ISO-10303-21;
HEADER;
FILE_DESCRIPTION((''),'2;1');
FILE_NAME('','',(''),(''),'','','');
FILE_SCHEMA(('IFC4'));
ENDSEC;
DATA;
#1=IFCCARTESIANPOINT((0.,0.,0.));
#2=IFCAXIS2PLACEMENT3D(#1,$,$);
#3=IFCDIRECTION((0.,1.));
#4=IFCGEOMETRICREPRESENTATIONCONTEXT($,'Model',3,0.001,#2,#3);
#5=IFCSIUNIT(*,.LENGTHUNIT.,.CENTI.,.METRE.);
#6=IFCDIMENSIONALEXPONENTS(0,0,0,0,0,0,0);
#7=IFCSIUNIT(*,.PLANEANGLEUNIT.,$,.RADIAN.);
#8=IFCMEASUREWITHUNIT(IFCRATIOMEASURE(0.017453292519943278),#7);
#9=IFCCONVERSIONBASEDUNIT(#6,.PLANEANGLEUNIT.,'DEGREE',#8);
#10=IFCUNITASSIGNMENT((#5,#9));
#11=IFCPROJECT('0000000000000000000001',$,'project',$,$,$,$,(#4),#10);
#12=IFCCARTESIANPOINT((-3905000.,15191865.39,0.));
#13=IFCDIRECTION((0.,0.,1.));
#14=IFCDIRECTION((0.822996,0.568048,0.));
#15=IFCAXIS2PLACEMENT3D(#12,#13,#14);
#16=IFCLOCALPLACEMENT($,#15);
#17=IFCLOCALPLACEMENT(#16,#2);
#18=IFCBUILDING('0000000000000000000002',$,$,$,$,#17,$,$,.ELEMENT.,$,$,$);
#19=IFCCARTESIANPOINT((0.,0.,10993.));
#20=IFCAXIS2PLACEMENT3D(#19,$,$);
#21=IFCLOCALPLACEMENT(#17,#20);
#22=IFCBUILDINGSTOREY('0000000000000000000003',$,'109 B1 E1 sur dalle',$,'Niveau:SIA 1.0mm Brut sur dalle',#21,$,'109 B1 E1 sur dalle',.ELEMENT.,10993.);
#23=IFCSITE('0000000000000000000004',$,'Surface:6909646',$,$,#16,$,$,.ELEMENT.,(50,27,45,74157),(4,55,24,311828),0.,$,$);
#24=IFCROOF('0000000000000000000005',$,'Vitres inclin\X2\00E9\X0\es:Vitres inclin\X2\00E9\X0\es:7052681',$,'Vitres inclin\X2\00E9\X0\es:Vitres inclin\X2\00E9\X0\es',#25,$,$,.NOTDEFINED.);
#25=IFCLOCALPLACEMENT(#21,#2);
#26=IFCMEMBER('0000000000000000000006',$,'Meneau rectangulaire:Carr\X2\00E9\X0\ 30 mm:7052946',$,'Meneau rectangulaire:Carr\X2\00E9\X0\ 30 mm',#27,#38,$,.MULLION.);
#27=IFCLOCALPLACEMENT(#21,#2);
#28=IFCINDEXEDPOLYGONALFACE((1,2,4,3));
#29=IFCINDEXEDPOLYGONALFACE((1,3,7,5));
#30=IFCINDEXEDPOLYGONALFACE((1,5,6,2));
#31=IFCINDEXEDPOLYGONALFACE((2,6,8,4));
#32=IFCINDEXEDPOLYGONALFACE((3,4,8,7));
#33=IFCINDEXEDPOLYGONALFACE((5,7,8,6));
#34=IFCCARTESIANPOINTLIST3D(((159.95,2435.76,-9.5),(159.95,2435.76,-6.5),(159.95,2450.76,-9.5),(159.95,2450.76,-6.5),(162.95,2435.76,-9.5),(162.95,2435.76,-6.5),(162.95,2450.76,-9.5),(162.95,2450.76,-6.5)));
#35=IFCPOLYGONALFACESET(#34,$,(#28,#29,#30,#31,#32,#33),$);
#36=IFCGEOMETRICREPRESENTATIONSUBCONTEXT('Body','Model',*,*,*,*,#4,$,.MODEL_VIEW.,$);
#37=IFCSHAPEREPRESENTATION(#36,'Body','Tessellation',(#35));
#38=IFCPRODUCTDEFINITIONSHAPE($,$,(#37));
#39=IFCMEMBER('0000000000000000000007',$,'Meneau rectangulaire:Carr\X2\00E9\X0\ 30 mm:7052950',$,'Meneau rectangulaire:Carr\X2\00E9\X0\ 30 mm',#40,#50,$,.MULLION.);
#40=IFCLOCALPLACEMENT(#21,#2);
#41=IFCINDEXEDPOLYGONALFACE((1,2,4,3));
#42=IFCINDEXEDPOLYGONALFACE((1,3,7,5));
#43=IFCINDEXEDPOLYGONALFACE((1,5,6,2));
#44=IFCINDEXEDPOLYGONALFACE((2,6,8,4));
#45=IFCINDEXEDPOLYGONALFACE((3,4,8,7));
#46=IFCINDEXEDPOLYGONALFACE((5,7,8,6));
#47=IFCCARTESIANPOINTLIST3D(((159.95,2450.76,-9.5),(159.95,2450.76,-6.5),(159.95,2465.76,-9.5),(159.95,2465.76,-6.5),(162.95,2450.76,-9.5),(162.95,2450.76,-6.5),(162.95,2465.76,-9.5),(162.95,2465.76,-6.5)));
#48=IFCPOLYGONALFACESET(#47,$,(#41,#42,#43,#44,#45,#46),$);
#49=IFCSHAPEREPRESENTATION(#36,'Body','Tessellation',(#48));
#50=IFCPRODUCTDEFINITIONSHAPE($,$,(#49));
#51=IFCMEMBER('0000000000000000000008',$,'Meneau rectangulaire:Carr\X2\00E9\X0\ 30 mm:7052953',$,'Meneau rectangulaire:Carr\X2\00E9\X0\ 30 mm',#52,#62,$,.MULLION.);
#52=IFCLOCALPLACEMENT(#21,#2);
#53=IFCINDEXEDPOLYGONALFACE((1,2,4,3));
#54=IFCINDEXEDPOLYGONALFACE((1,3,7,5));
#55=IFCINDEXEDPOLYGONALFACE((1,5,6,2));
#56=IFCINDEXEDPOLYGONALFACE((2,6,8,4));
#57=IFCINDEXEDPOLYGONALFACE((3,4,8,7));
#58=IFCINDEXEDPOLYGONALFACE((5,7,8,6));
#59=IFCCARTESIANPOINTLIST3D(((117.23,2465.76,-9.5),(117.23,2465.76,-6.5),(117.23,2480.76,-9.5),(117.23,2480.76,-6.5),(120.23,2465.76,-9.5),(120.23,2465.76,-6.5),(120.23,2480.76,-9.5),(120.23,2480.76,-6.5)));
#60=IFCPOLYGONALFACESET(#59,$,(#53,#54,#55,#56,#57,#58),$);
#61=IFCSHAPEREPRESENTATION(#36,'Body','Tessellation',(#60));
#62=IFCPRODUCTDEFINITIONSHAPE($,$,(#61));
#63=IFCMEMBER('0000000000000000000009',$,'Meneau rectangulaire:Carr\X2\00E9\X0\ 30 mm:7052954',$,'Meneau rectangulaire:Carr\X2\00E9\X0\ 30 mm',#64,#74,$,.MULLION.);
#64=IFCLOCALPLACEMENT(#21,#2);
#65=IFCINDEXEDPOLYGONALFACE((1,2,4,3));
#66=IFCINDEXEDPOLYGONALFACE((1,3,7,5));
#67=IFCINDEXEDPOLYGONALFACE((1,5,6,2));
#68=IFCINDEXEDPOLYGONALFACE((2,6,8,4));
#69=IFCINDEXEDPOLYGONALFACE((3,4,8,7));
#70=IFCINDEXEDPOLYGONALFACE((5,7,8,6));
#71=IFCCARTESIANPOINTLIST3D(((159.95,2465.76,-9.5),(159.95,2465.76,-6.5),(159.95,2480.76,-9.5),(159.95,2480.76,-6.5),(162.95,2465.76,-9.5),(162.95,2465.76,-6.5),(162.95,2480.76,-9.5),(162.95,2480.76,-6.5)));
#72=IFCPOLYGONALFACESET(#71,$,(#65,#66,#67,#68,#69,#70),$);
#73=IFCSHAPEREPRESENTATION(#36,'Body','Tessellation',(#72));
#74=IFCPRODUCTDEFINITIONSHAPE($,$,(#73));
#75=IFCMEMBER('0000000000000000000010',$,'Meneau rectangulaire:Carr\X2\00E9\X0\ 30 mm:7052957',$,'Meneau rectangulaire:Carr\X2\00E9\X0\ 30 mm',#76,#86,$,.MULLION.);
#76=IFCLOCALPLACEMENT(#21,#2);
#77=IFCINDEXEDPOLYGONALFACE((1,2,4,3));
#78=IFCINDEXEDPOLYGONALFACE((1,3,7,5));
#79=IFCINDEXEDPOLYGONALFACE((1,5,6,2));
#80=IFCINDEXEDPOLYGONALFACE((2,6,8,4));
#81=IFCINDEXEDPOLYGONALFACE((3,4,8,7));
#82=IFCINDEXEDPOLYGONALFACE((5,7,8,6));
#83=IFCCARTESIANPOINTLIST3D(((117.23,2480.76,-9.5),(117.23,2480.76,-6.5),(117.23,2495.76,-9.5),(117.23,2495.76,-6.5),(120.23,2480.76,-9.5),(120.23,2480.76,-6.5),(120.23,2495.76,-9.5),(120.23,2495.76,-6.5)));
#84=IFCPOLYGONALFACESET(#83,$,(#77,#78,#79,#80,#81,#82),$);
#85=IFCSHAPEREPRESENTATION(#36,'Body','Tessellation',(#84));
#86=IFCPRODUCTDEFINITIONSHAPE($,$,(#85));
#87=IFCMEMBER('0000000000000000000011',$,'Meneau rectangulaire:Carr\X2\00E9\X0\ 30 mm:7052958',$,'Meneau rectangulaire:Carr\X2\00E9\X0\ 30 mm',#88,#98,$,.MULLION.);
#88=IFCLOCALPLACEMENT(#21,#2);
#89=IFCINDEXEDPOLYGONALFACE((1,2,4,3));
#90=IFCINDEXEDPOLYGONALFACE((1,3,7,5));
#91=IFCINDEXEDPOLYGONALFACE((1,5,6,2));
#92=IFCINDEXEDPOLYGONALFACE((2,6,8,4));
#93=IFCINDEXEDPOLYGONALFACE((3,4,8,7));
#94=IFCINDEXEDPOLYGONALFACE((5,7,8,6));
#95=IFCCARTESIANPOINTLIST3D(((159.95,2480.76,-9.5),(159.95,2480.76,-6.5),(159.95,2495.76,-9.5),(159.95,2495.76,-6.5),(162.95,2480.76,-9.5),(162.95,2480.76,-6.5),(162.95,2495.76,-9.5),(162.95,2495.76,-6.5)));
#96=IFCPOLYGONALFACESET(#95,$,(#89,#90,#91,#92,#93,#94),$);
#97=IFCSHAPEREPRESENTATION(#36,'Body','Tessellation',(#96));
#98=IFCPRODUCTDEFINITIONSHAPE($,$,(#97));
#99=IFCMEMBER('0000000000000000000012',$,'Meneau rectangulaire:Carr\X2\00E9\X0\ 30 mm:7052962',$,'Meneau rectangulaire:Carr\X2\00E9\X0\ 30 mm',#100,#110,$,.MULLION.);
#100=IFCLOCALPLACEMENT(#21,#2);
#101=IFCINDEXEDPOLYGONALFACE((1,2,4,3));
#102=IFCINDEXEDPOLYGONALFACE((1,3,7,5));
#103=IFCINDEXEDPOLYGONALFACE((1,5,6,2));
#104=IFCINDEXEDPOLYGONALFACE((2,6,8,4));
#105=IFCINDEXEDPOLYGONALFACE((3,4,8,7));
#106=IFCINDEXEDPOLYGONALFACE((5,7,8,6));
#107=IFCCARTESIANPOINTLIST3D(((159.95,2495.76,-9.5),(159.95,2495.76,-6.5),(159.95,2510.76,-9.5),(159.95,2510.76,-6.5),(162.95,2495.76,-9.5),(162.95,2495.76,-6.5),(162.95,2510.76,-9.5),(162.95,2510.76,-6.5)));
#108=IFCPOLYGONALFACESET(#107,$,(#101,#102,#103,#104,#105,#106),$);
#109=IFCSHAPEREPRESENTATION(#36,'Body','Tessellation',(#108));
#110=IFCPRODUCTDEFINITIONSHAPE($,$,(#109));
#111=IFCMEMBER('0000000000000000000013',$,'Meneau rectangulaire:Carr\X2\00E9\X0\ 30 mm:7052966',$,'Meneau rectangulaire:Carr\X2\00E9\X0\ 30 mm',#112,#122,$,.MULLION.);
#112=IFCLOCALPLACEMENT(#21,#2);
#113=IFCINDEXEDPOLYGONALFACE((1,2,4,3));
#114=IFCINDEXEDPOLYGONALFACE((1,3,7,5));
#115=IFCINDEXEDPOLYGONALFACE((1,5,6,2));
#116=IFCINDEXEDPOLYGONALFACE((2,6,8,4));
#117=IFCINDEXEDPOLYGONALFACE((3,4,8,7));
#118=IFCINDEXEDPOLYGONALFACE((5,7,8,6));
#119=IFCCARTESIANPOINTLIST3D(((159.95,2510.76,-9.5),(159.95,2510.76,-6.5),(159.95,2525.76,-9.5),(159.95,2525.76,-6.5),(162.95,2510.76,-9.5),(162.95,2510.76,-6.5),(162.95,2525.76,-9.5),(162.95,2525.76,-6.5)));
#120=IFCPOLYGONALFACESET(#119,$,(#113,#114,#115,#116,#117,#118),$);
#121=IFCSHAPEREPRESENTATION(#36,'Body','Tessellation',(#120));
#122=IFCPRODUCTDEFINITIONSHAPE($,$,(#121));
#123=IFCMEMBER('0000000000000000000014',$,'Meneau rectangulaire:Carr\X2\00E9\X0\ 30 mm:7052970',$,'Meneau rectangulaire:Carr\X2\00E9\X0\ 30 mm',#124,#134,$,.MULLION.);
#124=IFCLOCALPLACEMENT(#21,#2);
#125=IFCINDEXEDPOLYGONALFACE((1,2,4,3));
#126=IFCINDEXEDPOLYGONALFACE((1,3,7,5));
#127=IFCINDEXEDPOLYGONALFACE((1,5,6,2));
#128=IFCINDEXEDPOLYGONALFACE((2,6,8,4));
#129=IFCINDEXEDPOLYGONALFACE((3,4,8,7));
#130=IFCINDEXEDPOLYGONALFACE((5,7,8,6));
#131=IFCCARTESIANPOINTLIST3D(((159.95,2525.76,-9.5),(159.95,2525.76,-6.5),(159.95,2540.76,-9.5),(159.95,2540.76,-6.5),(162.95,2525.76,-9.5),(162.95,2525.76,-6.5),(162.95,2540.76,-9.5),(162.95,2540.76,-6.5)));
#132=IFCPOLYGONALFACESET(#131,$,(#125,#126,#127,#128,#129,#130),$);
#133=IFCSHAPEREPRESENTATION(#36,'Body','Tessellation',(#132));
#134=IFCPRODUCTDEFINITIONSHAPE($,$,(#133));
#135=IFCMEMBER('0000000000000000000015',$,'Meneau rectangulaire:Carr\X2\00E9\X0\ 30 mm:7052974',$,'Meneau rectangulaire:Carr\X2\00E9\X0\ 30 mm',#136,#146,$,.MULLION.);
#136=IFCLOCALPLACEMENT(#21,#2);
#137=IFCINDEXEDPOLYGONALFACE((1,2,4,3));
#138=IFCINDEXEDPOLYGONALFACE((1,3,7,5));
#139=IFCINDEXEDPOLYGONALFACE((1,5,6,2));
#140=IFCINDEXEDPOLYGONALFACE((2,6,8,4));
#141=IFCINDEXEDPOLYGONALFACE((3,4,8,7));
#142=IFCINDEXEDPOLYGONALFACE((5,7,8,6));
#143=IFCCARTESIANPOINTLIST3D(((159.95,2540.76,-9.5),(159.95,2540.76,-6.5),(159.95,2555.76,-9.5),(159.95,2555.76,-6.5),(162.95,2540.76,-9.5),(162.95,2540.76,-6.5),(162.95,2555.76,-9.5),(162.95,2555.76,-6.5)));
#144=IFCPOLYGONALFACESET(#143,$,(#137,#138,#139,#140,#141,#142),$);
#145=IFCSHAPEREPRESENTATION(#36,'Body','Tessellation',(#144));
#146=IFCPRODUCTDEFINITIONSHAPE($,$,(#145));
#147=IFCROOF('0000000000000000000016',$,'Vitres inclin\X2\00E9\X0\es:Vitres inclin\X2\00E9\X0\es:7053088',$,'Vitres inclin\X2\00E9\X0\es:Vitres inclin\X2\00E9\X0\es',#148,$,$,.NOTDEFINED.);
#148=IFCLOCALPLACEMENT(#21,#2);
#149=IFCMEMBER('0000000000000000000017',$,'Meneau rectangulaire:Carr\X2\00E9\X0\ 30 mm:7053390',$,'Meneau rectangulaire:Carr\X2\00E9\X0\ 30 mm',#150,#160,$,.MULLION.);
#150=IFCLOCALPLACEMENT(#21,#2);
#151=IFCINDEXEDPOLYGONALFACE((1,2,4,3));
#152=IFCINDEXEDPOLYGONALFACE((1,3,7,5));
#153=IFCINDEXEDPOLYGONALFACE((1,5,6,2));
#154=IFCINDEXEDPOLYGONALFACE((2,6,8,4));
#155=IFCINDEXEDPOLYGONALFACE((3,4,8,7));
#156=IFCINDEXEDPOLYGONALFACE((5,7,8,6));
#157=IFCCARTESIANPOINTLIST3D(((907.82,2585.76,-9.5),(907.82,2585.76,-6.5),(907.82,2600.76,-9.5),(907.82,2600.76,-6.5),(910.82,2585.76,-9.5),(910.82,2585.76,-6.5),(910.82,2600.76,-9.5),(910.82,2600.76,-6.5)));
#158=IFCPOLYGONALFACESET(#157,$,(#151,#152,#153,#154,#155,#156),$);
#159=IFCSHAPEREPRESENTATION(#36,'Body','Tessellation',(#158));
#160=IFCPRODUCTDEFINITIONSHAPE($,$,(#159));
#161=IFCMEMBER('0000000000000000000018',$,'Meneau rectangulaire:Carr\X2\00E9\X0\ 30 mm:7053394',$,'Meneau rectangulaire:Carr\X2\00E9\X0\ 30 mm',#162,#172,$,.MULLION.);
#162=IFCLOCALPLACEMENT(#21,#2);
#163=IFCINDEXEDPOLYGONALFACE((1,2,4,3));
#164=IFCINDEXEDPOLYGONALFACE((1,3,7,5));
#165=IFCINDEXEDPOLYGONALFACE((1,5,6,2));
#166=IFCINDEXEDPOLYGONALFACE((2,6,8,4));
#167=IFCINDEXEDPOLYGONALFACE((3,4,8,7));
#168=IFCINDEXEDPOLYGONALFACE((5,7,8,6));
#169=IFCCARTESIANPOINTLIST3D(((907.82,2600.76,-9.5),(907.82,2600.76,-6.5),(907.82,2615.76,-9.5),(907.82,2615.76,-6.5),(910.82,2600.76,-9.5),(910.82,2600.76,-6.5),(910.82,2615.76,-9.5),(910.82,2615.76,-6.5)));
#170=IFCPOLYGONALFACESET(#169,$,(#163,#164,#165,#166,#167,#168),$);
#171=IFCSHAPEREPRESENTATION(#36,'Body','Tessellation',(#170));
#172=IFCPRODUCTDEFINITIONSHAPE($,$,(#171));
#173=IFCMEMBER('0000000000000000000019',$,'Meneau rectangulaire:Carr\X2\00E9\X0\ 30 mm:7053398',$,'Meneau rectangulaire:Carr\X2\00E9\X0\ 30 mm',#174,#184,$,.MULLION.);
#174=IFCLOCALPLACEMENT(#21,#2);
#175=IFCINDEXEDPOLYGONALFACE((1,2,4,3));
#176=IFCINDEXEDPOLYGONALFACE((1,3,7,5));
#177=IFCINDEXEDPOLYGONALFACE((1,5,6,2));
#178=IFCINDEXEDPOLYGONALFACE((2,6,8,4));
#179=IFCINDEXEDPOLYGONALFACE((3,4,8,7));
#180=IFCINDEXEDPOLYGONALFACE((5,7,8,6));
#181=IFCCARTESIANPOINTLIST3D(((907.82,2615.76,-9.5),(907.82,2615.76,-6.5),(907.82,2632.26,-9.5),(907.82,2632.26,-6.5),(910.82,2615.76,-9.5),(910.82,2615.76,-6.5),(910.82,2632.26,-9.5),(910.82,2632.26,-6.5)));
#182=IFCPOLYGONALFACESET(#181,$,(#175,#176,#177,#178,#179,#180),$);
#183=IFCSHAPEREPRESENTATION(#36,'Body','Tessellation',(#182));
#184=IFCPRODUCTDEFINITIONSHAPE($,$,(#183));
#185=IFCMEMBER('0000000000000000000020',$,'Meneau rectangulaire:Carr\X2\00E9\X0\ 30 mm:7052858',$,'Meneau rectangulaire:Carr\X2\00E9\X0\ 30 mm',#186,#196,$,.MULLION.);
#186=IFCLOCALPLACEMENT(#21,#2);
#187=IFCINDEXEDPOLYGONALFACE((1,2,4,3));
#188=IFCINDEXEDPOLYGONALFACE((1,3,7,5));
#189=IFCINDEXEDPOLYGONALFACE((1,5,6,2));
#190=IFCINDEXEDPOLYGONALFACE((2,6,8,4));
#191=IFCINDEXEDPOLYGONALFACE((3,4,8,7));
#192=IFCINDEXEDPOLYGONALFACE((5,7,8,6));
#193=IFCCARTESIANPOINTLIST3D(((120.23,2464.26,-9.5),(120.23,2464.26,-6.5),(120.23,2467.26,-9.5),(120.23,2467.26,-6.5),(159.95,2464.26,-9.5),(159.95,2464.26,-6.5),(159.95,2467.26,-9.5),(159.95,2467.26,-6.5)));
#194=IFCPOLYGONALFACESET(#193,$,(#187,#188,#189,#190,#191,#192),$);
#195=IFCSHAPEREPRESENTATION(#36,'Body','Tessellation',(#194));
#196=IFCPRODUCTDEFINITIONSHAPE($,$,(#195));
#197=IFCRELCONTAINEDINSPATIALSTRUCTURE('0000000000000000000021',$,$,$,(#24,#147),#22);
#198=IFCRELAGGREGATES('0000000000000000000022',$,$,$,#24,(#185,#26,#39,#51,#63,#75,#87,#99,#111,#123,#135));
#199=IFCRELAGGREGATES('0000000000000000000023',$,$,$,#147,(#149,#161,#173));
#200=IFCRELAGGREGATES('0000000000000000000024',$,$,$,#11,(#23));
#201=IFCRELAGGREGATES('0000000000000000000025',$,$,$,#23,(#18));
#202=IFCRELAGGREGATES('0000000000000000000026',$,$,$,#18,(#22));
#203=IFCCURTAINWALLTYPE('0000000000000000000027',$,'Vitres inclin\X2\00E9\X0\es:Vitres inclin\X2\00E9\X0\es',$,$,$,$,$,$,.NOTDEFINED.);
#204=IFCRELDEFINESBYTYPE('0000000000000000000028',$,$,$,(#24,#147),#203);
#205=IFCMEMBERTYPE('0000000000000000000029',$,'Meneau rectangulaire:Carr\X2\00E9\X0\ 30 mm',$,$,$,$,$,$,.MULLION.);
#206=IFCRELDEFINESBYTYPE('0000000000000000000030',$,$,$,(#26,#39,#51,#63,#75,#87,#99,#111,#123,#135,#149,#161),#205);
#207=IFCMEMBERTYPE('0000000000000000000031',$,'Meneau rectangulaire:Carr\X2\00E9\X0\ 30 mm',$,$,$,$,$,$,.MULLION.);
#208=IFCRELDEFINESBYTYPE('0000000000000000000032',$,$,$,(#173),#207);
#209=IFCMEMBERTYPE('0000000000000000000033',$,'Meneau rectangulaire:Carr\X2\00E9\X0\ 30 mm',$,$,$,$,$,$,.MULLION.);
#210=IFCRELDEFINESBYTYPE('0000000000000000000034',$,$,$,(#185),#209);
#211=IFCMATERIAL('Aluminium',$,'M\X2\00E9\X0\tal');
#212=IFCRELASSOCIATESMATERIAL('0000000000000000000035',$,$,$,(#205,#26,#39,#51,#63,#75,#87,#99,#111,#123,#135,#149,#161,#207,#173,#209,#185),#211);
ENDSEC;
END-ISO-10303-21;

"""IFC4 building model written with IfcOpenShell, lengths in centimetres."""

from ifc_helpers import new_model, entity, si_unit, converted_unit, direction, frame, origin, place, context, subcontext, project, spatial, indexed_curve, outline, extrude, source, transform, mapped, material, type_object, type_shapes, element, aggregate, save


model = new_model("IFC4")

# Units and contexts
model_context = context("Model", 3, precision=0.001, world=origin(), true_north=direction((0.0, 1.0)))
body_context = subcontext(model_context, "Body", "Model", "MODEL_VIEW")
ifc_project = project(units=[si_unit("LENGTHUNIT", "METRE", prefix="CENTI"), converted_unit("PLANEANGLEUNIT", "DEGREE", entity("IfcRatioMeasure", 0.017453292519943278), si_unit("PLANEANGLEUNIT", "RADIAN"), dimensions=[0, 0, 0, 0, 0, 0, 0])], contexts=[model_context])

# Site, building, storey
site_placement = place(None, frame((-3905000.0, 15191865.39, 0.0), z_axis=(0.0, 0.0, 1.0), x_axis=(0.822996, 0.568048, 0.0)))
site = spatial("IfcSite", under=ifc_project, at=site_placement, Name="Surface:6909646", CompositionType="ELEMENT", RefLatitude=(50, 27, 45, 74157), RefLongitude=(4, 55, 24, 311828), RefElevation=0.0)
building_placement = place(site_placement, origin())
building = spatial("IfcBuilding", under=site, at=building_placement, CompositionType="ELEMENT")
storey_placement = place(building_placement, frame((0.0, 0.0, 10993.0)))
storey = spatial("IfcBuildingStorey", under=building, at=storey_placement, Name="109 B1 E1 sur dalle", ObjectType="Niveau:SIA 1.0mm Brut sur dalle", LongName="109 B1 E1 sur dalle", CompositionType="ELEMENT", Elevation=10993.0)

# Roofs, members
curtain_wall_type = type_object("IfcCurtainWallType", Name="Vitres inclinées:Vitres inclinées", PredefinedType="NOTDEFINED")
roof_1_placement = place(storey_placement, frame((0.0, 0.0, -10993.0)))
roof_1 = element("IfcRoof", 1, at=roof_1_placement, inside=storey, type_object=curtain_wall_type, Name="Vitres inclinées:Vitres inclinées:7052681", ObjectType="Vitres inclinées:Vitres inclinées", PredefinedType="NOTDEFINED")
ifc_material = material(Name="Aluminium", Category="Métal")
member_type_1 = type_object("IfcMemberType", Name="Meneau rectangulaire:Carré 30 mm", PredefinedType="MULLION", material=ifc_material)
shared_shape_1 = source(origin(), body_context, "Body", "SweptSolid", [
    extrude(outline(indexed_curve([(-1.5, -1.5), (1.5, -1.5), (1.5, 1.5), (-1.5, 1.5), (-1.5, -1.5)], self_intersect=False)), frame((0.0, 0.0, -15.0), z_axis=(0.0, 0.0, 1.0), x_axis=(0.0, -1.0, 0.0)), (0.0, 0.0, 1.0), 15.0),
])
type_shapes(member_type_1, [shared_shape_1])
member_1_placement = place(roof_1_placement, frame((161.45, 2450.76, 10985.0), z_axis=(0.0, 1.0, 0.0), x_axis=(1.0, 0.0, 0.0)))
member_1 = element("IfcMember", 2, at=member_1_placement, type_object=member_type_1, material=ifc_material, Name="Meneau rectangulaire:Carré 30 mm:7052946", ObjectType="Meneau rectangulaire:Carré 30 mm", PredefinedType="MULLION", context=body_context, shape_type="MappedRepresentation", body=[
    mapped(shared_shape_1, transform((0.0, 0.0, 0.0), scale=1.0)),
])
member_2_placement = place(roof_1_placement, frame((161.45, 2465.76, 10985.0), z_axis=(0.0, 1.0, 0.0), x_axis=(1.0, 0.0, 0.0)))
member_2 = element("IfcMember", 3, at=member_2_placement, type_object=member_type_1, material=ifc_material, Name="Meneau rectangulaire:Carré 30 mm:7052950", ObjectType="Meneau rectangulaire:Carré 30 mm", PredefinedType="MULLION", context=body_context, shape_type="MappedRepresentation", body=[
    mapped(shared_shape_1, transform((0.0, 0.0, 0.0), scale=1.0)),
])
member_3_placement = place(roof_1_placement, frame((118.73, 2480.76, 10985.0), z_axis=(0.0, 1.0, 0.0), x_axis=(1.0, 0.0, 0.0)))
member_3 = element("IfcMember", 4, at=member_3_placement, type_object=member_type_1, material=ifc_material, Name="Meneau rectangulaire:Carré 30 mm:7052953", ObjectType="Meneau rectangulaire:Carré 30 mm", PredefinedType="MULLION", context=body_context, shape_type="MappedRepresentation", body=[
    mapped(shared_shape_1, transform((0.0, 0.0, 0.0), scale=1.0)),
])
member_4_placement = place(roof_1_placement, frame((161.45, 2480.76, 10985.0), z_axis=(0.0, 1.0, 0.0), x_axis=(1.0, 0.0, 0.0)))
member_4 = element("IfcMember", 5, at=member_4_placement, type_object=member_type_1, material=ifc_material, Name="Meneau rectangulaire:Carré 30 mm:7052954", ObjectType="Meneau rectangulaire:Carré 30 mm", PredefinedType="MULLION", context=body_context, shape_type="MappedRepresentation", body=[
    mapped(shared_shape_1, transform((0.0, 0.0, 0.0), scale=1.0)),
])
member_5_placement = place(roof_1_placement, frame((118.73, 2495.76, 10985.0), z_axis=(0.0, 1.0, 0.0), x_axis=(1.0, 0.0, 0.0)))
member_5 = element("IfcMember", 6, at=member_5_placement, type_object=member_type_1, material=ifc_material, Name="Meneau rectangulaire:Carré 30 mm:7052957", ObjectType="Meneau rectangulaire:Carré 30 mm", PredefinedType="MULLION", context=body_context, shape_type="MappedRepresentation", body=[
    mapped(shared_shape_1, transform((0.0, 0.0, 0.0), scale=1.0)),
])
member_6_placement = place(roof_1_placement, frame((161.45, 2495.76, 10985.0), z_axis=(0.0, 1.0, 0.0), x_axis=(1.0, 0.0, 0.0)))
member_6 = element("IfcMember", 7, at=member_6_placement, type_object=member_type_1, material=ifc_material, Name="Meneau rectangulaire:Carré 30 mm:7052958", ObjectType="Meneau rectangulaire:Carré 30 mm", PredefinedType="MULLION", context=body_context, shape_type="MappedRepresentation", body=[
    mapped(shared_shape_1, transform((0.0, 0.0, 0.0), scale=1.0)),
])
member_7_placement = place(roof_1_placement, frame((161.45, 2510.76, 10985.0), z_axis=(0.0, 1.0, 0.0), x_axis=(1.0, 0.0, 0.0)))
member_7 = element("IfcMember", 8, at=member_7_placement, type_object=member_type_1, material=ifc_material, Name="Meneau rectangulaire:Carré 30 mm:7052962", ObjectType="Meneau rectangulaire:Carré 30 mm", PredefinedType="MULLION", context=body_context, shape_type="MappedRepresentation", body=[
    mapped(shared_shape_1, transform((0.0, 0.0, 0.0), scale=1.0)),
])
member_8_placement = place(roof_1_placement, frame((161.45, 2525.76, 10985.0), z_axis=(0.0, 1.0, 0.0), x_axis=(1.0, 0.0, 0.0)))
member_8 = element("IfcMember", 9, at=member_8_placement, type_object=member_type_1, material=ifc_material, Name="Meneau rectangulaire:Carré 30 mm:7052966", ObjectType="Meneau rectangulaire:Carré 30 mm", PredefinedType="MULLION", context=body_context, shape_type="MappedRepresentation", body=[
    mapped(shared_shape_1, transform((0.0, 0.0, 0.0), scale=1.0)),
])
member_9_placement = place(roof_1_placement, frame((161.45, 2540.76, 10985.0), z_axis=(0.0, 1.0, 0.0), x_axis=(1.0, 0.0, 0.0)))
member_9 = element("IfcMember", 10, at=member_9_placement, type_object=member_type_1, material=ifc_material, Name="Meneau rectangulaire:Carré 30 mm:7052970", ObjectType="Meneau rectangulaire:Carré 30 mm", PredefinedType="MULLION", context=body_context, shape_type="MappedRepresentation", body=[
    mapped(shared_shape_1, transform((0.0, 0.0, 0.0), scale=1.0)),
])
member_10_placement = place(roof_1_placement, frame((161.45, 2555.76, 10985.0), z_axis=(0.0, 1.0, 0.0), x_axis=(1.0, 0.0, 0.0)))
member_10 = element("IfcMember", 11, at=member_10_placement, type_object=member_type_1, material=ifc_material, Name="Meneau rectangulaire:Carré 30 mm:7052974", ObjectType="Meneau rectangulaire:Carré 30 mm", PredefinedType="MULLION", context=body_context, shape_type="MappedRepresentation", body=[
    mapped(shared_shape_1, transform((0.0, 0.0, 0.0), scale=1.0)),
])
roof_2_placement = place(storey_placement, frame((0.0, 0.0, -10993.0)))
roof_2 = element("IfcRoof", 12, at=roof_2_placement, inside=storey, type_object=curtain_wall_type, Name="Vitres inclinées:Vitres inclinées:7053088", ObjectType="Vitres inclinées:Vitres inclinées", PredefinedType="NOTDEFINED")
member_11_placement = place(roof_2_placement, frame((909.32, 2600.76, 10985.0), z_axis=(0.0, 1.0, 0.0), x_axis=(1.0, 0.0, 0.0)))
member_11 = element("IfcMember", 13, at=member_11_placement, type_object=member_type_1, material=ifc_material, Name="Meneau rectangulaire:Carré 30 mm:7053390", ObjectType="Meneau rectangulaire:Carré 30 mm", PredefinedType="MULLION", context=body_context, shape_type="MappedRepresentation", body=[
    mapped(shared_shape_1, transform((0.0, 0.0, 0.0), scale=1.0)),
])
member_12_placement = place(roof_2_placement, frame((909.32, 2615.76, 10985.0), z_axis=(0.0, 1.0, 0.0), x_axis=(1.0, 0.0, 0.0)))
member_12 = element("IfcMember", 14, at=member_12_placement, type_object=member_type_1, material=ifc_material, Name="Meneau rectangulaire:Carré 30 mm:7053394", ObjectType="Meneau rectangulaire:Carré 30 mm", PredefinedType="MULLION", context=body_context, shape_type="MappedRepresentation", body=[
    mapped(shared_shape_1, transform((0.0, 0.0, 0.0), scale=1.0)),
])
member_type_2 = type_object("IfcMemberType", Name="Meneau rectangulaire:Carré 30 mm", PredefinedType="MULLION", material=ifc_material)
shared_shape_2 = source(origin(), body_context, "Body", "SweptSolid", [
    extrude(outline(indexed_curve([(-1.5, -1.5), (1.5, -1.5), (1.5, 1.5), (-1.5, 1.5), (-1.5, -1.5)], self_intersect=False)), frame((0.0, 0.0, -16.5), z_axis=(0.0, 0.0, 1.0), x_axis=(0.0, -1.0, 0.0)), (0.0, 0.0, 1.0), 16.5),
])
type_shapes(member_type_2, [shared_shape_2])
member_13_placement = place(roof_2_placement, frame((909.32, 2632.26, 10985.0), z_axis=(0.0, 1.0, 0.0), x_axis=(1.0, 0.0, 0.0)))
member_13 = element("IfcMember", 15, at=member_13_placement, type_object=member_type_2, material=ifc_material, Name="Meneau rectangulaire:Carré 30 mm:7053398", ObjectType="Meneau rectangulaire:Carré 30 mm", PredefinedType="MULLION", context=body_context, shape_type="MappedRepresentation", body=[
    mapped(shared_shape_2, transform((0.0, 0.0, 0.0), scale=1.0)),
])

# Member
member_type_3 = type_object("IfcMemberType", Name="Meneau rectangulaire:Carré 30 mm", PredefinedType="MULLION", material=ifc_material)
shared_shape_3 = source(origin(), body_context, "Body", "SweptSolid", [
    extrude(outline(indexed_curve([(-1.5, -1.5), (1.5, -1.5), (1.5, 1.5), (-1.5, 1.5), (-1.5, -1.5)], self_intersect=False)), frame((0.0, 0.0, -39.72), z_axis=(0.0, 0.0, 1.0), x_axis=(0.0, -1.0, 0.0)), (0.0, 0.0, 1.0), 39.72),
])
type_shapes(member_type_3, [shared_shape_3])
member_14_placement = place(roof_1_placement, frame((120.23, 2465.76, 10985.0), z_axis=(-1.0, 0.0, 0.0), x_axis=(0.0, 1.0, 0.0)))
member_14 = element("IfcMember", 16, at=member_14_placement, type_object=member_type_3, material=ifc_material, Name="Meneau rectangulaire:Carré 30 mm:7052858", ObjectType="Meneau rectangulaire:Carré 30 mm", PredefinedType="MULLION", context=body_context, shape_type="MappedRepresentation", body=[
    mapped(shared_shape_3, transform((0.0, 0.0, 0.0), scale=1.0)),
])
aggregate(roof_1, [member_14, member_1, member_2, member_3, member_4, member_5, member_6, member_7, member_8, member_9, member_10])
aggregate(roof_2, [member_11, member_12, member_13])

save(model, "model.ifc")
